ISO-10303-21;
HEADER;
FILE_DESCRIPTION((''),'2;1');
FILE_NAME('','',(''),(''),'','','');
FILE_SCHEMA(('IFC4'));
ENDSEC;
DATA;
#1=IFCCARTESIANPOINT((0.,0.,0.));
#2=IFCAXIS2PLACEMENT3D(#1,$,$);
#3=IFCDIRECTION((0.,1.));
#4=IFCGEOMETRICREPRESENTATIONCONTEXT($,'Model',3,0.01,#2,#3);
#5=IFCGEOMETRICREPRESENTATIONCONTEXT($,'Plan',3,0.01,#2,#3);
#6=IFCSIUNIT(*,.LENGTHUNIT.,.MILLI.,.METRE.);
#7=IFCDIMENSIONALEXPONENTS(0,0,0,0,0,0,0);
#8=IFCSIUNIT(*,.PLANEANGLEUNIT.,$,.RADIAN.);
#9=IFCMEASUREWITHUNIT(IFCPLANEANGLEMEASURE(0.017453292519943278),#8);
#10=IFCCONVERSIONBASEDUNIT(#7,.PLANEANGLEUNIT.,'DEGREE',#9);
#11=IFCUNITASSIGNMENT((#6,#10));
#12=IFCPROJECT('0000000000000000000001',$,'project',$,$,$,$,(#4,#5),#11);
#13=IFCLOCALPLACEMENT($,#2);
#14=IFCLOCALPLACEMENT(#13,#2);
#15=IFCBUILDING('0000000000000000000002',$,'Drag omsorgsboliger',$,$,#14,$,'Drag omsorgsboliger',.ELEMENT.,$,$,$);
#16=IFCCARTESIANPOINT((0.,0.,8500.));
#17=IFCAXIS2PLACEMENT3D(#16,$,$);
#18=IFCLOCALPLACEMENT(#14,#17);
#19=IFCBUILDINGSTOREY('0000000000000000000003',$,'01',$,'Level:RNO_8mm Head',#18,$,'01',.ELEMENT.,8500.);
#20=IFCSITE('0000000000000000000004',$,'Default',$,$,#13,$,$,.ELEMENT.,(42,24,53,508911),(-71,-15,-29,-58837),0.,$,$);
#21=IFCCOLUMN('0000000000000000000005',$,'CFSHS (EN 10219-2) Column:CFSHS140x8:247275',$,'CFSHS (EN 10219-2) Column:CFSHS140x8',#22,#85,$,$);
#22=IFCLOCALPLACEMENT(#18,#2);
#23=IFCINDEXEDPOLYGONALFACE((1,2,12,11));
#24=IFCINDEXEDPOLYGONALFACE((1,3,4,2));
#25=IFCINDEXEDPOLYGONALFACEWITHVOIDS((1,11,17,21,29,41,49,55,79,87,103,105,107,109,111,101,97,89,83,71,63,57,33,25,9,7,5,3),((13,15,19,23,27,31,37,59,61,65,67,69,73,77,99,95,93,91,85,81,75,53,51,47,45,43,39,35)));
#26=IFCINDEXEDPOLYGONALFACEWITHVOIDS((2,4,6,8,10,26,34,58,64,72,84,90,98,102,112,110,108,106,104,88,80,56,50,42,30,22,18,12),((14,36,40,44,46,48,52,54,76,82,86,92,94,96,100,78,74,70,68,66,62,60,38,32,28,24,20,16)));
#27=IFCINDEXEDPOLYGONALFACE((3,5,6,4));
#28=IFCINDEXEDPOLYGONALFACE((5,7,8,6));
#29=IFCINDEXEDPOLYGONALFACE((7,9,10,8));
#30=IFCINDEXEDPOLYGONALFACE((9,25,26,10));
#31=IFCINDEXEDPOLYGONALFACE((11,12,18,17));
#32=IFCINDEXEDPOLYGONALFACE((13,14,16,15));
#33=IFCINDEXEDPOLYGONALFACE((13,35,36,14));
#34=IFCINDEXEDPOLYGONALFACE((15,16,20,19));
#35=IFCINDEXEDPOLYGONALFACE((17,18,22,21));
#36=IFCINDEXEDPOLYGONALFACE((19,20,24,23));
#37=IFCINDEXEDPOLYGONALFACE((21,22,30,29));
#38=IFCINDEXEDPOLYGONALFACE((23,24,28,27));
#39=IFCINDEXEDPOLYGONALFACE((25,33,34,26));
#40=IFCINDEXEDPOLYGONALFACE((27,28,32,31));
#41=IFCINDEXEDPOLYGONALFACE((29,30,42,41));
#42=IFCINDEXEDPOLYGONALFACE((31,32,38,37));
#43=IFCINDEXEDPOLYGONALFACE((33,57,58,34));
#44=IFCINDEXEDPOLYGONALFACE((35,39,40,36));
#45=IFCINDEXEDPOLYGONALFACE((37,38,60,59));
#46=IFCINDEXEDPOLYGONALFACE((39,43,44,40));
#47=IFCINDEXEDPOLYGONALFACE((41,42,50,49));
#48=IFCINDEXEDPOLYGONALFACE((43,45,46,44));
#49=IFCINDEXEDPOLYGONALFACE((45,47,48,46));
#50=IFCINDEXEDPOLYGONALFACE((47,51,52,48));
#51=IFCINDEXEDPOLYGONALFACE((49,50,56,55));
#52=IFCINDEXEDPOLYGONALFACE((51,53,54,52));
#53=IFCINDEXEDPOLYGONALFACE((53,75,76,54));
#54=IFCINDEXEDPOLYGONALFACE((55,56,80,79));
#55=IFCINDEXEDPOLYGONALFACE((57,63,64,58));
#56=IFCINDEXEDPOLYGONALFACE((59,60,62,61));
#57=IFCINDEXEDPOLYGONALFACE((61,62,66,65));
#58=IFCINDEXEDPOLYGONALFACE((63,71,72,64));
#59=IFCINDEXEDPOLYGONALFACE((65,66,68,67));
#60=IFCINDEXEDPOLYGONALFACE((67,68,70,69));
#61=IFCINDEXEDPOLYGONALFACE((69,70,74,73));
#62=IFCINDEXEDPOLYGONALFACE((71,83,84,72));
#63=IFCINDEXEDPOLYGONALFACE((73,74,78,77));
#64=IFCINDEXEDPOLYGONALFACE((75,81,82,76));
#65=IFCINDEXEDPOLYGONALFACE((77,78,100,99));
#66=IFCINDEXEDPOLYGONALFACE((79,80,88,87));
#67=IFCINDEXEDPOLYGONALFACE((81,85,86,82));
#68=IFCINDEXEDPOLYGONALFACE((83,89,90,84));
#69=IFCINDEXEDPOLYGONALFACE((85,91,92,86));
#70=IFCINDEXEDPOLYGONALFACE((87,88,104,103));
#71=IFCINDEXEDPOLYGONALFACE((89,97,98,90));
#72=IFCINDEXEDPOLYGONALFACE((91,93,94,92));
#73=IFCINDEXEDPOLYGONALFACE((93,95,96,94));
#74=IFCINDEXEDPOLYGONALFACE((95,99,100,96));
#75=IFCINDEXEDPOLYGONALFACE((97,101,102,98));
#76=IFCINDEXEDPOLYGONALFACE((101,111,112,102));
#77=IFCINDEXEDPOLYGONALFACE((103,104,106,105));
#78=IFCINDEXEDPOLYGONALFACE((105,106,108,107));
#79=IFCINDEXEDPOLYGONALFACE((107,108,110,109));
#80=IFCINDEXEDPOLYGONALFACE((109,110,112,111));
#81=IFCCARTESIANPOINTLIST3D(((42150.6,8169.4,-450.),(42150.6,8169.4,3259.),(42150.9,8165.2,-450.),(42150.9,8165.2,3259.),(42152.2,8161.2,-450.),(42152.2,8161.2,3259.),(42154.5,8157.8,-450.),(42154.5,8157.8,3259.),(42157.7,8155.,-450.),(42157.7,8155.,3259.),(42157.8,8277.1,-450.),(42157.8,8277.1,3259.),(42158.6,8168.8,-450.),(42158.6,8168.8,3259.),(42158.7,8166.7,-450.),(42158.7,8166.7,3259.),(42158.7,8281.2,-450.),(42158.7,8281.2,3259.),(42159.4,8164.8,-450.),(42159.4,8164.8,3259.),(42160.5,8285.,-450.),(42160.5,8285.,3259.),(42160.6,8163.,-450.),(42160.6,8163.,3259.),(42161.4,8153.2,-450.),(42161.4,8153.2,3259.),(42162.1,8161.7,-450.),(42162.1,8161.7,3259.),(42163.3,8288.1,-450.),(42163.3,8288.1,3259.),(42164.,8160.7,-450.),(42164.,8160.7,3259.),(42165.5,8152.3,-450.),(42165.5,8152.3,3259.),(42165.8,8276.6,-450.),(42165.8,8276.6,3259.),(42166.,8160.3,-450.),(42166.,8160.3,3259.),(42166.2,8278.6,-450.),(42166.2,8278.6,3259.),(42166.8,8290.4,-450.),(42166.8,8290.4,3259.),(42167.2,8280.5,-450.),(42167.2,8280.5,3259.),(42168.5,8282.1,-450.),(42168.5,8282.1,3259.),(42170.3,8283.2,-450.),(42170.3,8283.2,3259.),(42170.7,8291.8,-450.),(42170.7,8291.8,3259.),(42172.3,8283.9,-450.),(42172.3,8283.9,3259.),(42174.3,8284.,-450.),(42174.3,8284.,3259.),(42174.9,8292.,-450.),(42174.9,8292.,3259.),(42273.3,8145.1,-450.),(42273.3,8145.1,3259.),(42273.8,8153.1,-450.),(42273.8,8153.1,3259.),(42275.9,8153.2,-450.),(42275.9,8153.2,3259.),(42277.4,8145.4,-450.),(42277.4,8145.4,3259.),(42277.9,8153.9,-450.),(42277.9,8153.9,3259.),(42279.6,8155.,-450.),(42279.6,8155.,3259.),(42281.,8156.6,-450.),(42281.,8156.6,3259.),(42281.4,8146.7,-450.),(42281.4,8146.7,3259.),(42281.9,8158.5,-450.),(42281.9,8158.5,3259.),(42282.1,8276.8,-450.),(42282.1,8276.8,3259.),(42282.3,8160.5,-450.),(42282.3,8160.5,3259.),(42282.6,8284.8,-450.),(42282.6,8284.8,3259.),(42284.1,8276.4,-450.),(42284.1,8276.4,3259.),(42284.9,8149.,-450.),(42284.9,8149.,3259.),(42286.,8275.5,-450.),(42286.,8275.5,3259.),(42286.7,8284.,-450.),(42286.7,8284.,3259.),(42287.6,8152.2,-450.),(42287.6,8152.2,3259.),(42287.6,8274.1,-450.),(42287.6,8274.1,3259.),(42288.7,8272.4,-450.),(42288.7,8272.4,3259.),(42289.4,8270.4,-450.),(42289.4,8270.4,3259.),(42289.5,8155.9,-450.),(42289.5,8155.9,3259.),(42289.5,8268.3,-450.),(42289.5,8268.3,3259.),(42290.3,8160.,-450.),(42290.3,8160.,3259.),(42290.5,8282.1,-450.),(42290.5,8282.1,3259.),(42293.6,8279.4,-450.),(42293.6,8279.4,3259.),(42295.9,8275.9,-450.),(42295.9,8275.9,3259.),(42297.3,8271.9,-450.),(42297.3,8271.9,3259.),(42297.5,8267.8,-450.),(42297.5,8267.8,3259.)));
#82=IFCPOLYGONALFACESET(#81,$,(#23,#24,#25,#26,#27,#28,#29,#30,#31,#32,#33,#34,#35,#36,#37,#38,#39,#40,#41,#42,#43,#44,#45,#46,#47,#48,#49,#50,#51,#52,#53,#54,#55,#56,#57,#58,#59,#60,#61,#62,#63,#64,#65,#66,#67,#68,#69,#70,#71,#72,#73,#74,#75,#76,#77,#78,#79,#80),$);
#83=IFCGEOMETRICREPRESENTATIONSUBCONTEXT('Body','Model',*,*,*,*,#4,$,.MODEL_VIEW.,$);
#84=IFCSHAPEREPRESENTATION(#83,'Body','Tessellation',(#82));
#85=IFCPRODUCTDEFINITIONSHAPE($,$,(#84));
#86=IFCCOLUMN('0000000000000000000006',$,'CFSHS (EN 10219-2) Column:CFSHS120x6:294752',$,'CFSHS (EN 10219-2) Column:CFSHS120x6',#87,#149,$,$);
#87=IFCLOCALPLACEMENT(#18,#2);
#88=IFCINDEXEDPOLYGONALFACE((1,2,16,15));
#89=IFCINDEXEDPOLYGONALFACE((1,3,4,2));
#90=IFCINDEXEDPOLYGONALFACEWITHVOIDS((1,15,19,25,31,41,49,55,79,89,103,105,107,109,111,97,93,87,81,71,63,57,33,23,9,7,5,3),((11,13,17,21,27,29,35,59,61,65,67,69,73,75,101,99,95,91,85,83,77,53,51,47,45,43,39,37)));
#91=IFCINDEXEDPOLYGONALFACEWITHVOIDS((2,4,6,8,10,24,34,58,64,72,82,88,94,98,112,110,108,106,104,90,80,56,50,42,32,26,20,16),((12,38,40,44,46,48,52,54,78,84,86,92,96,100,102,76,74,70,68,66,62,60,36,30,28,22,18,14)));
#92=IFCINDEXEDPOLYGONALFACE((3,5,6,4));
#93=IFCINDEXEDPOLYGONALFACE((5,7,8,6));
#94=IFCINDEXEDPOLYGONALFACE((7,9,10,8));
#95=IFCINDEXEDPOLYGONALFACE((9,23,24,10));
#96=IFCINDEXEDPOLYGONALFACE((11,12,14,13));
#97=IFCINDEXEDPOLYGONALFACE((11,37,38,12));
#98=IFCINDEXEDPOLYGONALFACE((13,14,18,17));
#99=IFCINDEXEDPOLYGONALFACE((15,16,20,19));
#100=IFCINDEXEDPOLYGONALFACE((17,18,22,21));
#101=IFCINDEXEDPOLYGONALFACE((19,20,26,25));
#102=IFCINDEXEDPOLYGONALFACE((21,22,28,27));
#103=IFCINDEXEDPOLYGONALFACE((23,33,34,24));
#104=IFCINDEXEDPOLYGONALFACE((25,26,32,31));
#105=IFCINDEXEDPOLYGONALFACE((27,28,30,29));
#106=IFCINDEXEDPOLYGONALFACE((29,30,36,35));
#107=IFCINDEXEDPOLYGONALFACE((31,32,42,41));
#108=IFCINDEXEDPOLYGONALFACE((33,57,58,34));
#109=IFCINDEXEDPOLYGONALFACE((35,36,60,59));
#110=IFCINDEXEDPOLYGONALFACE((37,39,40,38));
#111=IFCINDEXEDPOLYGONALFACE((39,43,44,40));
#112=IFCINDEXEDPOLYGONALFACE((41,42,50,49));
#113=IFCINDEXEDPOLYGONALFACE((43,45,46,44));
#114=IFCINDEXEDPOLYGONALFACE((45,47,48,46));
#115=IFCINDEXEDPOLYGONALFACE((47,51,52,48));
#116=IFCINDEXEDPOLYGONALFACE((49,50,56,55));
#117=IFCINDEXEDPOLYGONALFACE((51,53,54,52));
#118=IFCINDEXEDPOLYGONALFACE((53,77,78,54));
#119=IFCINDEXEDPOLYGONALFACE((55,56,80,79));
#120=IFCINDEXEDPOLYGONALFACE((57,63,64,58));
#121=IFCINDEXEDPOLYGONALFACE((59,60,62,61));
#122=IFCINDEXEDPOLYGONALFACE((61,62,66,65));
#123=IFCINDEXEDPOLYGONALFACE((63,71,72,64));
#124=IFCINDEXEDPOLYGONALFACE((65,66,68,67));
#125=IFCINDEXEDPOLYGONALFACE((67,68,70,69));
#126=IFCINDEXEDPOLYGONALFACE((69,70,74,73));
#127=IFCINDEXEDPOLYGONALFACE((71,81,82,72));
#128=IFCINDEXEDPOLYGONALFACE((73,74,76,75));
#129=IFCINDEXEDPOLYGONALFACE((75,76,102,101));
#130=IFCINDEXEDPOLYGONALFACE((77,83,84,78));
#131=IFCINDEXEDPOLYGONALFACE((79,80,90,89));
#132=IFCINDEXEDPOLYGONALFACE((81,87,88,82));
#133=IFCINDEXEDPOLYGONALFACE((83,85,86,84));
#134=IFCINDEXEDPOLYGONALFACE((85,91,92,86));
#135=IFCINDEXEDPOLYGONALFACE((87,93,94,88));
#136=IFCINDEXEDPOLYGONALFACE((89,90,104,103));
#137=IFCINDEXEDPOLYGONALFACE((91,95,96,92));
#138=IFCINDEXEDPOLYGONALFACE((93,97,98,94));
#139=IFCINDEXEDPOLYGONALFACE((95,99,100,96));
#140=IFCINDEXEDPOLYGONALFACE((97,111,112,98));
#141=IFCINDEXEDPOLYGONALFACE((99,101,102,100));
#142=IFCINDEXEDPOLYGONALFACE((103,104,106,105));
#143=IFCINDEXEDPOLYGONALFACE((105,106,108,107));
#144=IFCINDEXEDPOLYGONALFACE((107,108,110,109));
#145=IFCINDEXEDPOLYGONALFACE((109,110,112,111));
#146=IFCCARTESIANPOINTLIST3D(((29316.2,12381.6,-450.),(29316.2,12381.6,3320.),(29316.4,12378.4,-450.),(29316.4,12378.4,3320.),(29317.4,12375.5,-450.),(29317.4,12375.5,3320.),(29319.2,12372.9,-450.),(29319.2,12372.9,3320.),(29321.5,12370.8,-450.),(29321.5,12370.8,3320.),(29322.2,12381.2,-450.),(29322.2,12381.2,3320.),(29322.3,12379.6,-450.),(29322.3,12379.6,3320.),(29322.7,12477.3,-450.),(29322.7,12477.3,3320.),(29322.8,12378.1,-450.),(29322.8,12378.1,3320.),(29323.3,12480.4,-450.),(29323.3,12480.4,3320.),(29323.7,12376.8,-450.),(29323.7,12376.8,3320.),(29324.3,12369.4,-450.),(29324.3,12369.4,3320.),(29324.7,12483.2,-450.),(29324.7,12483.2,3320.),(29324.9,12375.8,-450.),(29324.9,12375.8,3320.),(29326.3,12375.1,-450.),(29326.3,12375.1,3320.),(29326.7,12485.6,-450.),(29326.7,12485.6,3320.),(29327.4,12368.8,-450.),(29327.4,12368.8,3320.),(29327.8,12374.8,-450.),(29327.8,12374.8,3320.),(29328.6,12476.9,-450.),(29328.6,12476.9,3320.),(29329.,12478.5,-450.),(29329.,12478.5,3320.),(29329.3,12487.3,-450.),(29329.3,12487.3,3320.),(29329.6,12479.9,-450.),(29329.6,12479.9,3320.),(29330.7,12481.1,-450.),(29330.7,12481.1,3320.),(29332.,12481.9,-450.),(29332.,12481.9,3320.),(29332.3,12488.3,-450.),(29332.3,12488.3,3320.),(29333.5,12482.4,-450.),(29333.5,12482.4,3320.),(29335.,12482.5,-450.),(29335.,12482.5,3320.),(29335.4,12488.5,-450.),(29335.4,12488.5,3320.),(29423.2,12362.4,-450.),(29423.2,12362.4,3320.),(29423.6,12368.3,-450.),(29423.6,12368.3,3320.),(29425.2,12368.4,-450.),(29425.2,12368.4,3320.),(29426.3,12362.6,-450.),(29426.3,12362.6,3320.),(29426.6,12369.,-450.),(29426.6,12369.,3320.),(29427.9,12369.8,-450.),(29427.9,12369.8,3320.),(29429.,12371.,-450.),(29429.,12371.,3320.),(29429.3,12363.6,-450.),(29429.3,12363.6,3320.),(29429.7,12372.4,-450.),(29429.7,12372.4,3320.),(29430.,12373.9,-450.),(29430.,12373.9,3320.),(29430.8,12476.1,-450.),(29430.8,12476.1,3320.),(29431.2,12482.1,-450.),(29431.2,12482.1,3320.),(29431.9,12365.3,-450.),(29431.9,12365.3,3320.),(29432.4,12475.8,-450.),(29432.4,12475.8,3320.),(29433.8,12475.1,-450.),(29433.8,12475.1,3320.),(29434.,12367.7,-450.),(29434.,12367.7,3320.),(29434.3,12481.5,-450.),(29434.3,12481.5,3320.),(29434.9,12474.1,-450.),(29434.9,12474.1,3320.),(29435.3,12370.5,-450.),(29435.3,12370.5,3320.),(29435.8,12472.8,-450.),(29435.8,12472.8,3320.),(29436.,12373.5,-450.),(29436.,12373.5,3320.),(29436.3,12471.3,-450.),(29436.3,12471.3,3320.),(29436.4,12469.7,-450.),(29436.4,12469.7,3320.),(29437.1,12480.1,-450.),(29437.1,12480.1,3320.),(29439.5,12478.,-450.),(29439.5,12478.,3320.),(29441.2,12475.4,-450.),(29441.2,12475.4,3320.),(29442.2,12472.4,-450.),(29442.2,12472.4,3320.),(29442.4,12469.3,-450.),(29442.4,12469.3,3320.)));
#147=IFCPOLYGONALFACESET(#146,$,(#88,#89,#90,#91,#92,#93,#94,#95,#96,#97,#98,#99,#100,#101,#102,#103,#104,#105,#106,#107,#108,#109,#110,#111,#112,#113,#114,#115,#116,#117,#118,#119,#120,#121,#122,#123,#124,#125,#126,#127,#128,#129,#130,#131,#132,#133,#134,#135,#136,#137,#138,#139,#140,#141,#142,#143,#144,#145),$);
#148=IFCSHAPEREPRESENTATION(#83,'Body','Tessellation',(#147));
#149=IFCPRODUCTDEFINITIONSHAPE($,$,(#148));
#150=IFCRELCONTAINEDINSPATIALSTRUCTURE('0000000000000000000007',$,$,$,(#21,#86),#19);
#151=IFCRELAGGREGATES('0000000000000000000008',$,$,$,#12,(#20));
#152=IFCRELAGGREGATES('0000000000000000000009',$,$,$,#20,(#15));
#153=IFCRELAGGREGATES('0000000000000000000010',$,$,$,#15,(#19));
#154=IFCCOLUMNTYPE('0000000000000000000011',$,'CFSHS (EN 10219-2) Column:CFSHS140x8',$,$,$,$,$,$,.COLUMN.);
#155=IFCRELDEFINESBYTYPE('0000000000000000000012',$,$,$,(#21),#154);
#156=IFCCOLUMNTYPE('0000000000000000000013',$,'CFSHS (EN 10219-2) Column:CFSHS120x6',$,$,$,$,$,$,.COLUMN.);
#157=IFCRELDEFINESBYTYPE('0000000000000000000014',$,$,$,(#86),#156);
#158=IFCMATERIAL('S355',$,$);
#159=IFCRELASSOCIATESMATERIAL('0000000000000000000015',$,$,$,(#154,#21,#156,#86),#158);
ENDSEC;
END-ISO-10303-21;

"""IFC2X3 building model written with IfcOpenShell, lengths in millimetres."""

from ifc_helpers import new_model, entity, si_unit, converted_unit, direction, frame, frame_2d, origin, place, context, subcontext, project, spatial, polyline, circle_curve, parameter, trimmed, segment, composite_curve, outline, extrude, source, transform, mapped, material, type_object, type_shapes, element, save


model = new_model("IFC2X3")

# Units and contexts
model_context = context("Model", 3, precision=0.01, world=origin(), true_north=direction((0.0, 1.0)))
plan_context = context("Plan", 3, precision=0.01, world=origin(), true_north=direction((0.0, 1.0)))
body_context = subcontext(model_context, "Body", "Model", "MODEL_VIEW")
ifc_project = project(units=[si_unit("LENGTHUNIT", "METRE", prefix="MILLI"), converted_unit("PLANEANGLEUNIT", "DEGREE", entity("IfcPlaneAngleMeasure", 0.017453292519943278), si_unit("PLANEANGLEUNIT", "RADIAN"), dimensions=[0, 0, 0, 0, 0, 0, 0])], contexts=[model_context, plan_context])

# Site, building, storey
site_placement = place(None, origin())
site = spatial("IfcSite", under=ifc_project, at=site_placement, Name="Default", CompositionType="ELEMENT", RefLatitude=(42, 24, 53, 508911), RefLongitude=(-71, -15, -29, -58837), RefElevation=0.0)
building_placement = place(site_placement, origin())
building = spatial("IfcBuilding", under=site, at=building_placement, Name="Drag omsorgsboliger", LongName="Drag omsorgsboliger", CompositionType="ELEMENT")
storey_placement = place(building_placement, frame((0.0, 0.0, 8500.0)))
storey = spatial("IfcBuildingStorey", under=building, at=storey_placement, Name="01", ObjectType="Level:RNO_8mm Head", LongName="01", CompositionType="ELEMENT", Elevation=8500.0)

# Columns
ifc_material = material(Name="S355")
column_type_1 = type_object("IfcColumnType", Name="CFSHS (EN 10219-2) Column:CFSHS140x8", PredefinedType="COLUMN", material=ifc_material)
shared_shape_1 = source(origin(), body_context, "Body", "SweptSolid", [
    extrude(outline(composite_curve([segment(polyline([(-54.0, -70.0), (54.0, -70.0)]), True, "CONTINUOUS"), segment(trimmed(circle_curve(frame_2d((54.0, -54.0), x_axis=(-1.0, 0.0)), 16.0), [parameter(90.0)], [parameter(180.0)], True, "PARAMETER"), True, "CONTINUOUS"), segment(polyline([(70.0, -54.0), (70.0, 54.0)]), True, "CONTINUOUS"), segment(trimmed(circle_curve(frame_2d((54.0, 54.0), x_axis=(-1.0, 0.0)), 16.0), [parameter(180.0)], [parameter(270.0)], True, "PARAMETER"), True, "CONTINUOUS"), segment(polyline([(54.0, 70.0), (-54.0, 70.0)]), True, "CONTINUOUS"), segment(trimmed(circle_curve(frame_2d((-54.0, 54.0), x_axis=(-1.0, 0.0)), 16.0), [parameter(270.0)], [parameter(360.0)], True, "PARAMETER"), True, "CONTINUOUS"), segment(polyline([(-70.0, 54.0), (-70.0, -54.0)]), True, "CONTINUOUS"), segment(trimmed(circle_curve(frame_2d((-54.0, -54.0), x_axis=(-1.0, 0.0)), 16.0), [parameter(360.0)], [parameter(90.0)], True, "PARAMETER"), True, "CONTINUOUS")], self_intersect=False), holes=[composite_curve([segment(trimmed(circle_curve(frame_2d((-54.0, -54.0), x_axis=(-1.0, 0.0)), 8.0), [parameter(360.0)], [parameter(90.0)], True, "PARAMETER"), False, "CONTINUOUS"), segment(polyline([(-62.0, -54.0), (-62.0, 54.0)]), True, "CONTINUOUS"), segment(trimmed(circle_curve(frame_2d((-54.0, 54.0), x_axis=(-1.0, 0.0)), 8.0), [parameter(270.0)], [parameter(360.0)], True, "PARAMETER"), False, "CONTINUOUS"), segment(polyline([(-54.0, 62.0), (54.0, 62.0)]), True, "CONTINUOUS"), segment(trimmed(circle_curve(frame_2d((54.0, 54.0), x_axis=(-1.0, 0.0)), 8.0), [parameter(180.0)], [parameter(270.0)], True, "PARAMETER"), False, "CONTINUOUS"), segment(polyline([(62.0, 54.0), (62.0, -54.0)]), True, "CONTINUOUS"), segment(trimmed(circle_curve(frame_2d((54.0, -54.0), x_axis=(-1.0, 0.0)), 8.0), [parameter(90.0)], [parameter(180.0)], True, "PARAMETER"), False, "CONTINUOUS"), segment(polyline([(54.0, -62.0), (-54.0, -62.0)]), True, "CONTINUOUS")], self_intersect=False)]), frame((42224.1, 8218.6, 8050.0), z_axis=(0.0, 0.0, 1.0), x_axis=(-0.997758, 0.066923, 0.0)), (0.0, 0.0, 1.0), 3709.0),
])
type_shapes(column_type_1, [shared_shape_1])
column_1_placement = place(storey_placement, frame((0.0, 0.0, -8500.0)))
element("IfcColumn", 1, at=column_1_placement, inside=storey, type_object=column_type_1, material=ifc_material, Name="CFSHS (EN 10219-2) Column:CFSHS140x8:247275", ObjectType="CFSHS (EN 10219-2) Column:CFSHS140x8", context=body_context, shape_type="MappedRepresentation", body=[
    mapped(shared_shape_1, transform((0.0, 0.0, 0.0), scale=1.0)),
])
column_type_2 = type_object("IfcColumnType", Name="CFSHS (EN 10219-2) Column:CFSHS120x6", PredefinedType="COLUMN", material=ifc_material)
shared_shape_2 = source(origin(), body_context, "Body", "SweptSolid", [
    extrude(outline(composite_curve([segment(polyline([(-48.0, -60.0), (48.0, -60.0)]), True, "CONTINUOUS"), segment(trimmed(circle_curve(frame_2d((48.0, -48.0), x_axis=(-1.0, 0.0)), 12.0), [parameter(90.0)], [parameter(180.0)], True, "PARAMETER"), True, "CONTINUOUS"), segment(polyline([(60.0, -48.0), (60.0, 48.0)]), True, "CONTINUOUS"), segment(trimmed(circle_curve(frame_2d((48.0, 48.0), x_axis=(-1.0, 0.0)), 12.0), [parameter(180.0)], [parameter(270.0)], True, "PARAMETER"), True, "CONTINUOUS"), segment(polyline([(48.0, 60.0), (-48.0, 60.0)]), True, "CONTINUOUS"), segment(trimmed(circle_curve(frame_2d((-48.0, 48.0), x_axis=(-1.0, 0.0)), 12.0), [parameter(270.0)], [parameter(360.0)], True, "PARAMETER"), True, "CONTINUOUS"), segment(polyline([(-60.0, 48.0), (-60.0, -48.0)]), True, "CONTINUOUS"), segment(trimmed(circle_curve(frame_2d((-48.0, -48.0), x_axis=(-1.0, 0.0)), 12.0), [parameter(360.0)], [parameter(90.0)], True, "PARAMETER"), True, "CONTINUOUS")], self_intersect=False), holes=[composite_curve([segment(trimmed(circle_curve(frame_2d((-48.0, -48.0), x_axis=(-1.0, 0.0)), 6.0), [parameter(360.0)], [parameter(90.0)], True, "PARAMETER"), False, "CONTINUOUS"), segment(polyline([(-54.0, -48.0), (-54.0, 48.0)]), True, "CONTINUOUS"), segment(trimmed(circle_curve(frame_2d((-48.0, 48.0), x_axis=(-1.0, 0.0)), 6.0), [parameter(270.0)], [parameter(360.0)], True, "PARAMETER"), False, "CONTINUOUS"), segment(polyline([(-48.0, 54.0), (48.0, 54.0)]), True, "CONTINUOUS"), segment(trimmed(circle_curve(frame_2d((48.0, 48.0), x_axis=(-1.0, 0.0)), 6.0), [parameter(180.0)], [parameter(270.0)], True, "PARAMETER"), False, "CONTINUOUS"), segment(polyline([(54.0, 48.0), (54.0, -48.0)]), True, "CONTINUOUS"), segment(trimmed(circle_curve(frame_2d((48.0, -48.0), x_axis=(-1.0, 0.0)), 6.0), [parameter(90.0)], [parameter(180.0)], True, "PARAMETER"), False, "CONTINUOUS"), segment(polyline([(48.0, -54.0), (-48.0, -54.0)]), True, "CONTINUOUS")], self_intersect=False)]), frame((29379.3, 12425.4, 8050.0), z_axis=(0.0, 0.0, 1.0), x_axis=(-0.997758, 0.066923, 0.0)), (0.0, 0.0, 1.0), 3770.0),
])
type_shapes(column_type_2, [shared_shape_2])
column_2_placement = place(storey_placement, frame((0.0, 0.0, -8500.0)))
element("IfcColumn", 2, at=column_2_placement, inside=storey, type_object=column_type_2, material=ifc_material, Name="CFSHS (EN 10219-2) Column:CFSHS120x6:294752", ObjectType="CFSHS (EN 10219-2) Column:CFSHS120x6", context=body_context, shape_type="MappedRepresentation", body=[
    mapped(shared_shape_2, transform((0.0, 0.0, 0.0), scale=1.0)),
])

save(model, "model.ifc")
